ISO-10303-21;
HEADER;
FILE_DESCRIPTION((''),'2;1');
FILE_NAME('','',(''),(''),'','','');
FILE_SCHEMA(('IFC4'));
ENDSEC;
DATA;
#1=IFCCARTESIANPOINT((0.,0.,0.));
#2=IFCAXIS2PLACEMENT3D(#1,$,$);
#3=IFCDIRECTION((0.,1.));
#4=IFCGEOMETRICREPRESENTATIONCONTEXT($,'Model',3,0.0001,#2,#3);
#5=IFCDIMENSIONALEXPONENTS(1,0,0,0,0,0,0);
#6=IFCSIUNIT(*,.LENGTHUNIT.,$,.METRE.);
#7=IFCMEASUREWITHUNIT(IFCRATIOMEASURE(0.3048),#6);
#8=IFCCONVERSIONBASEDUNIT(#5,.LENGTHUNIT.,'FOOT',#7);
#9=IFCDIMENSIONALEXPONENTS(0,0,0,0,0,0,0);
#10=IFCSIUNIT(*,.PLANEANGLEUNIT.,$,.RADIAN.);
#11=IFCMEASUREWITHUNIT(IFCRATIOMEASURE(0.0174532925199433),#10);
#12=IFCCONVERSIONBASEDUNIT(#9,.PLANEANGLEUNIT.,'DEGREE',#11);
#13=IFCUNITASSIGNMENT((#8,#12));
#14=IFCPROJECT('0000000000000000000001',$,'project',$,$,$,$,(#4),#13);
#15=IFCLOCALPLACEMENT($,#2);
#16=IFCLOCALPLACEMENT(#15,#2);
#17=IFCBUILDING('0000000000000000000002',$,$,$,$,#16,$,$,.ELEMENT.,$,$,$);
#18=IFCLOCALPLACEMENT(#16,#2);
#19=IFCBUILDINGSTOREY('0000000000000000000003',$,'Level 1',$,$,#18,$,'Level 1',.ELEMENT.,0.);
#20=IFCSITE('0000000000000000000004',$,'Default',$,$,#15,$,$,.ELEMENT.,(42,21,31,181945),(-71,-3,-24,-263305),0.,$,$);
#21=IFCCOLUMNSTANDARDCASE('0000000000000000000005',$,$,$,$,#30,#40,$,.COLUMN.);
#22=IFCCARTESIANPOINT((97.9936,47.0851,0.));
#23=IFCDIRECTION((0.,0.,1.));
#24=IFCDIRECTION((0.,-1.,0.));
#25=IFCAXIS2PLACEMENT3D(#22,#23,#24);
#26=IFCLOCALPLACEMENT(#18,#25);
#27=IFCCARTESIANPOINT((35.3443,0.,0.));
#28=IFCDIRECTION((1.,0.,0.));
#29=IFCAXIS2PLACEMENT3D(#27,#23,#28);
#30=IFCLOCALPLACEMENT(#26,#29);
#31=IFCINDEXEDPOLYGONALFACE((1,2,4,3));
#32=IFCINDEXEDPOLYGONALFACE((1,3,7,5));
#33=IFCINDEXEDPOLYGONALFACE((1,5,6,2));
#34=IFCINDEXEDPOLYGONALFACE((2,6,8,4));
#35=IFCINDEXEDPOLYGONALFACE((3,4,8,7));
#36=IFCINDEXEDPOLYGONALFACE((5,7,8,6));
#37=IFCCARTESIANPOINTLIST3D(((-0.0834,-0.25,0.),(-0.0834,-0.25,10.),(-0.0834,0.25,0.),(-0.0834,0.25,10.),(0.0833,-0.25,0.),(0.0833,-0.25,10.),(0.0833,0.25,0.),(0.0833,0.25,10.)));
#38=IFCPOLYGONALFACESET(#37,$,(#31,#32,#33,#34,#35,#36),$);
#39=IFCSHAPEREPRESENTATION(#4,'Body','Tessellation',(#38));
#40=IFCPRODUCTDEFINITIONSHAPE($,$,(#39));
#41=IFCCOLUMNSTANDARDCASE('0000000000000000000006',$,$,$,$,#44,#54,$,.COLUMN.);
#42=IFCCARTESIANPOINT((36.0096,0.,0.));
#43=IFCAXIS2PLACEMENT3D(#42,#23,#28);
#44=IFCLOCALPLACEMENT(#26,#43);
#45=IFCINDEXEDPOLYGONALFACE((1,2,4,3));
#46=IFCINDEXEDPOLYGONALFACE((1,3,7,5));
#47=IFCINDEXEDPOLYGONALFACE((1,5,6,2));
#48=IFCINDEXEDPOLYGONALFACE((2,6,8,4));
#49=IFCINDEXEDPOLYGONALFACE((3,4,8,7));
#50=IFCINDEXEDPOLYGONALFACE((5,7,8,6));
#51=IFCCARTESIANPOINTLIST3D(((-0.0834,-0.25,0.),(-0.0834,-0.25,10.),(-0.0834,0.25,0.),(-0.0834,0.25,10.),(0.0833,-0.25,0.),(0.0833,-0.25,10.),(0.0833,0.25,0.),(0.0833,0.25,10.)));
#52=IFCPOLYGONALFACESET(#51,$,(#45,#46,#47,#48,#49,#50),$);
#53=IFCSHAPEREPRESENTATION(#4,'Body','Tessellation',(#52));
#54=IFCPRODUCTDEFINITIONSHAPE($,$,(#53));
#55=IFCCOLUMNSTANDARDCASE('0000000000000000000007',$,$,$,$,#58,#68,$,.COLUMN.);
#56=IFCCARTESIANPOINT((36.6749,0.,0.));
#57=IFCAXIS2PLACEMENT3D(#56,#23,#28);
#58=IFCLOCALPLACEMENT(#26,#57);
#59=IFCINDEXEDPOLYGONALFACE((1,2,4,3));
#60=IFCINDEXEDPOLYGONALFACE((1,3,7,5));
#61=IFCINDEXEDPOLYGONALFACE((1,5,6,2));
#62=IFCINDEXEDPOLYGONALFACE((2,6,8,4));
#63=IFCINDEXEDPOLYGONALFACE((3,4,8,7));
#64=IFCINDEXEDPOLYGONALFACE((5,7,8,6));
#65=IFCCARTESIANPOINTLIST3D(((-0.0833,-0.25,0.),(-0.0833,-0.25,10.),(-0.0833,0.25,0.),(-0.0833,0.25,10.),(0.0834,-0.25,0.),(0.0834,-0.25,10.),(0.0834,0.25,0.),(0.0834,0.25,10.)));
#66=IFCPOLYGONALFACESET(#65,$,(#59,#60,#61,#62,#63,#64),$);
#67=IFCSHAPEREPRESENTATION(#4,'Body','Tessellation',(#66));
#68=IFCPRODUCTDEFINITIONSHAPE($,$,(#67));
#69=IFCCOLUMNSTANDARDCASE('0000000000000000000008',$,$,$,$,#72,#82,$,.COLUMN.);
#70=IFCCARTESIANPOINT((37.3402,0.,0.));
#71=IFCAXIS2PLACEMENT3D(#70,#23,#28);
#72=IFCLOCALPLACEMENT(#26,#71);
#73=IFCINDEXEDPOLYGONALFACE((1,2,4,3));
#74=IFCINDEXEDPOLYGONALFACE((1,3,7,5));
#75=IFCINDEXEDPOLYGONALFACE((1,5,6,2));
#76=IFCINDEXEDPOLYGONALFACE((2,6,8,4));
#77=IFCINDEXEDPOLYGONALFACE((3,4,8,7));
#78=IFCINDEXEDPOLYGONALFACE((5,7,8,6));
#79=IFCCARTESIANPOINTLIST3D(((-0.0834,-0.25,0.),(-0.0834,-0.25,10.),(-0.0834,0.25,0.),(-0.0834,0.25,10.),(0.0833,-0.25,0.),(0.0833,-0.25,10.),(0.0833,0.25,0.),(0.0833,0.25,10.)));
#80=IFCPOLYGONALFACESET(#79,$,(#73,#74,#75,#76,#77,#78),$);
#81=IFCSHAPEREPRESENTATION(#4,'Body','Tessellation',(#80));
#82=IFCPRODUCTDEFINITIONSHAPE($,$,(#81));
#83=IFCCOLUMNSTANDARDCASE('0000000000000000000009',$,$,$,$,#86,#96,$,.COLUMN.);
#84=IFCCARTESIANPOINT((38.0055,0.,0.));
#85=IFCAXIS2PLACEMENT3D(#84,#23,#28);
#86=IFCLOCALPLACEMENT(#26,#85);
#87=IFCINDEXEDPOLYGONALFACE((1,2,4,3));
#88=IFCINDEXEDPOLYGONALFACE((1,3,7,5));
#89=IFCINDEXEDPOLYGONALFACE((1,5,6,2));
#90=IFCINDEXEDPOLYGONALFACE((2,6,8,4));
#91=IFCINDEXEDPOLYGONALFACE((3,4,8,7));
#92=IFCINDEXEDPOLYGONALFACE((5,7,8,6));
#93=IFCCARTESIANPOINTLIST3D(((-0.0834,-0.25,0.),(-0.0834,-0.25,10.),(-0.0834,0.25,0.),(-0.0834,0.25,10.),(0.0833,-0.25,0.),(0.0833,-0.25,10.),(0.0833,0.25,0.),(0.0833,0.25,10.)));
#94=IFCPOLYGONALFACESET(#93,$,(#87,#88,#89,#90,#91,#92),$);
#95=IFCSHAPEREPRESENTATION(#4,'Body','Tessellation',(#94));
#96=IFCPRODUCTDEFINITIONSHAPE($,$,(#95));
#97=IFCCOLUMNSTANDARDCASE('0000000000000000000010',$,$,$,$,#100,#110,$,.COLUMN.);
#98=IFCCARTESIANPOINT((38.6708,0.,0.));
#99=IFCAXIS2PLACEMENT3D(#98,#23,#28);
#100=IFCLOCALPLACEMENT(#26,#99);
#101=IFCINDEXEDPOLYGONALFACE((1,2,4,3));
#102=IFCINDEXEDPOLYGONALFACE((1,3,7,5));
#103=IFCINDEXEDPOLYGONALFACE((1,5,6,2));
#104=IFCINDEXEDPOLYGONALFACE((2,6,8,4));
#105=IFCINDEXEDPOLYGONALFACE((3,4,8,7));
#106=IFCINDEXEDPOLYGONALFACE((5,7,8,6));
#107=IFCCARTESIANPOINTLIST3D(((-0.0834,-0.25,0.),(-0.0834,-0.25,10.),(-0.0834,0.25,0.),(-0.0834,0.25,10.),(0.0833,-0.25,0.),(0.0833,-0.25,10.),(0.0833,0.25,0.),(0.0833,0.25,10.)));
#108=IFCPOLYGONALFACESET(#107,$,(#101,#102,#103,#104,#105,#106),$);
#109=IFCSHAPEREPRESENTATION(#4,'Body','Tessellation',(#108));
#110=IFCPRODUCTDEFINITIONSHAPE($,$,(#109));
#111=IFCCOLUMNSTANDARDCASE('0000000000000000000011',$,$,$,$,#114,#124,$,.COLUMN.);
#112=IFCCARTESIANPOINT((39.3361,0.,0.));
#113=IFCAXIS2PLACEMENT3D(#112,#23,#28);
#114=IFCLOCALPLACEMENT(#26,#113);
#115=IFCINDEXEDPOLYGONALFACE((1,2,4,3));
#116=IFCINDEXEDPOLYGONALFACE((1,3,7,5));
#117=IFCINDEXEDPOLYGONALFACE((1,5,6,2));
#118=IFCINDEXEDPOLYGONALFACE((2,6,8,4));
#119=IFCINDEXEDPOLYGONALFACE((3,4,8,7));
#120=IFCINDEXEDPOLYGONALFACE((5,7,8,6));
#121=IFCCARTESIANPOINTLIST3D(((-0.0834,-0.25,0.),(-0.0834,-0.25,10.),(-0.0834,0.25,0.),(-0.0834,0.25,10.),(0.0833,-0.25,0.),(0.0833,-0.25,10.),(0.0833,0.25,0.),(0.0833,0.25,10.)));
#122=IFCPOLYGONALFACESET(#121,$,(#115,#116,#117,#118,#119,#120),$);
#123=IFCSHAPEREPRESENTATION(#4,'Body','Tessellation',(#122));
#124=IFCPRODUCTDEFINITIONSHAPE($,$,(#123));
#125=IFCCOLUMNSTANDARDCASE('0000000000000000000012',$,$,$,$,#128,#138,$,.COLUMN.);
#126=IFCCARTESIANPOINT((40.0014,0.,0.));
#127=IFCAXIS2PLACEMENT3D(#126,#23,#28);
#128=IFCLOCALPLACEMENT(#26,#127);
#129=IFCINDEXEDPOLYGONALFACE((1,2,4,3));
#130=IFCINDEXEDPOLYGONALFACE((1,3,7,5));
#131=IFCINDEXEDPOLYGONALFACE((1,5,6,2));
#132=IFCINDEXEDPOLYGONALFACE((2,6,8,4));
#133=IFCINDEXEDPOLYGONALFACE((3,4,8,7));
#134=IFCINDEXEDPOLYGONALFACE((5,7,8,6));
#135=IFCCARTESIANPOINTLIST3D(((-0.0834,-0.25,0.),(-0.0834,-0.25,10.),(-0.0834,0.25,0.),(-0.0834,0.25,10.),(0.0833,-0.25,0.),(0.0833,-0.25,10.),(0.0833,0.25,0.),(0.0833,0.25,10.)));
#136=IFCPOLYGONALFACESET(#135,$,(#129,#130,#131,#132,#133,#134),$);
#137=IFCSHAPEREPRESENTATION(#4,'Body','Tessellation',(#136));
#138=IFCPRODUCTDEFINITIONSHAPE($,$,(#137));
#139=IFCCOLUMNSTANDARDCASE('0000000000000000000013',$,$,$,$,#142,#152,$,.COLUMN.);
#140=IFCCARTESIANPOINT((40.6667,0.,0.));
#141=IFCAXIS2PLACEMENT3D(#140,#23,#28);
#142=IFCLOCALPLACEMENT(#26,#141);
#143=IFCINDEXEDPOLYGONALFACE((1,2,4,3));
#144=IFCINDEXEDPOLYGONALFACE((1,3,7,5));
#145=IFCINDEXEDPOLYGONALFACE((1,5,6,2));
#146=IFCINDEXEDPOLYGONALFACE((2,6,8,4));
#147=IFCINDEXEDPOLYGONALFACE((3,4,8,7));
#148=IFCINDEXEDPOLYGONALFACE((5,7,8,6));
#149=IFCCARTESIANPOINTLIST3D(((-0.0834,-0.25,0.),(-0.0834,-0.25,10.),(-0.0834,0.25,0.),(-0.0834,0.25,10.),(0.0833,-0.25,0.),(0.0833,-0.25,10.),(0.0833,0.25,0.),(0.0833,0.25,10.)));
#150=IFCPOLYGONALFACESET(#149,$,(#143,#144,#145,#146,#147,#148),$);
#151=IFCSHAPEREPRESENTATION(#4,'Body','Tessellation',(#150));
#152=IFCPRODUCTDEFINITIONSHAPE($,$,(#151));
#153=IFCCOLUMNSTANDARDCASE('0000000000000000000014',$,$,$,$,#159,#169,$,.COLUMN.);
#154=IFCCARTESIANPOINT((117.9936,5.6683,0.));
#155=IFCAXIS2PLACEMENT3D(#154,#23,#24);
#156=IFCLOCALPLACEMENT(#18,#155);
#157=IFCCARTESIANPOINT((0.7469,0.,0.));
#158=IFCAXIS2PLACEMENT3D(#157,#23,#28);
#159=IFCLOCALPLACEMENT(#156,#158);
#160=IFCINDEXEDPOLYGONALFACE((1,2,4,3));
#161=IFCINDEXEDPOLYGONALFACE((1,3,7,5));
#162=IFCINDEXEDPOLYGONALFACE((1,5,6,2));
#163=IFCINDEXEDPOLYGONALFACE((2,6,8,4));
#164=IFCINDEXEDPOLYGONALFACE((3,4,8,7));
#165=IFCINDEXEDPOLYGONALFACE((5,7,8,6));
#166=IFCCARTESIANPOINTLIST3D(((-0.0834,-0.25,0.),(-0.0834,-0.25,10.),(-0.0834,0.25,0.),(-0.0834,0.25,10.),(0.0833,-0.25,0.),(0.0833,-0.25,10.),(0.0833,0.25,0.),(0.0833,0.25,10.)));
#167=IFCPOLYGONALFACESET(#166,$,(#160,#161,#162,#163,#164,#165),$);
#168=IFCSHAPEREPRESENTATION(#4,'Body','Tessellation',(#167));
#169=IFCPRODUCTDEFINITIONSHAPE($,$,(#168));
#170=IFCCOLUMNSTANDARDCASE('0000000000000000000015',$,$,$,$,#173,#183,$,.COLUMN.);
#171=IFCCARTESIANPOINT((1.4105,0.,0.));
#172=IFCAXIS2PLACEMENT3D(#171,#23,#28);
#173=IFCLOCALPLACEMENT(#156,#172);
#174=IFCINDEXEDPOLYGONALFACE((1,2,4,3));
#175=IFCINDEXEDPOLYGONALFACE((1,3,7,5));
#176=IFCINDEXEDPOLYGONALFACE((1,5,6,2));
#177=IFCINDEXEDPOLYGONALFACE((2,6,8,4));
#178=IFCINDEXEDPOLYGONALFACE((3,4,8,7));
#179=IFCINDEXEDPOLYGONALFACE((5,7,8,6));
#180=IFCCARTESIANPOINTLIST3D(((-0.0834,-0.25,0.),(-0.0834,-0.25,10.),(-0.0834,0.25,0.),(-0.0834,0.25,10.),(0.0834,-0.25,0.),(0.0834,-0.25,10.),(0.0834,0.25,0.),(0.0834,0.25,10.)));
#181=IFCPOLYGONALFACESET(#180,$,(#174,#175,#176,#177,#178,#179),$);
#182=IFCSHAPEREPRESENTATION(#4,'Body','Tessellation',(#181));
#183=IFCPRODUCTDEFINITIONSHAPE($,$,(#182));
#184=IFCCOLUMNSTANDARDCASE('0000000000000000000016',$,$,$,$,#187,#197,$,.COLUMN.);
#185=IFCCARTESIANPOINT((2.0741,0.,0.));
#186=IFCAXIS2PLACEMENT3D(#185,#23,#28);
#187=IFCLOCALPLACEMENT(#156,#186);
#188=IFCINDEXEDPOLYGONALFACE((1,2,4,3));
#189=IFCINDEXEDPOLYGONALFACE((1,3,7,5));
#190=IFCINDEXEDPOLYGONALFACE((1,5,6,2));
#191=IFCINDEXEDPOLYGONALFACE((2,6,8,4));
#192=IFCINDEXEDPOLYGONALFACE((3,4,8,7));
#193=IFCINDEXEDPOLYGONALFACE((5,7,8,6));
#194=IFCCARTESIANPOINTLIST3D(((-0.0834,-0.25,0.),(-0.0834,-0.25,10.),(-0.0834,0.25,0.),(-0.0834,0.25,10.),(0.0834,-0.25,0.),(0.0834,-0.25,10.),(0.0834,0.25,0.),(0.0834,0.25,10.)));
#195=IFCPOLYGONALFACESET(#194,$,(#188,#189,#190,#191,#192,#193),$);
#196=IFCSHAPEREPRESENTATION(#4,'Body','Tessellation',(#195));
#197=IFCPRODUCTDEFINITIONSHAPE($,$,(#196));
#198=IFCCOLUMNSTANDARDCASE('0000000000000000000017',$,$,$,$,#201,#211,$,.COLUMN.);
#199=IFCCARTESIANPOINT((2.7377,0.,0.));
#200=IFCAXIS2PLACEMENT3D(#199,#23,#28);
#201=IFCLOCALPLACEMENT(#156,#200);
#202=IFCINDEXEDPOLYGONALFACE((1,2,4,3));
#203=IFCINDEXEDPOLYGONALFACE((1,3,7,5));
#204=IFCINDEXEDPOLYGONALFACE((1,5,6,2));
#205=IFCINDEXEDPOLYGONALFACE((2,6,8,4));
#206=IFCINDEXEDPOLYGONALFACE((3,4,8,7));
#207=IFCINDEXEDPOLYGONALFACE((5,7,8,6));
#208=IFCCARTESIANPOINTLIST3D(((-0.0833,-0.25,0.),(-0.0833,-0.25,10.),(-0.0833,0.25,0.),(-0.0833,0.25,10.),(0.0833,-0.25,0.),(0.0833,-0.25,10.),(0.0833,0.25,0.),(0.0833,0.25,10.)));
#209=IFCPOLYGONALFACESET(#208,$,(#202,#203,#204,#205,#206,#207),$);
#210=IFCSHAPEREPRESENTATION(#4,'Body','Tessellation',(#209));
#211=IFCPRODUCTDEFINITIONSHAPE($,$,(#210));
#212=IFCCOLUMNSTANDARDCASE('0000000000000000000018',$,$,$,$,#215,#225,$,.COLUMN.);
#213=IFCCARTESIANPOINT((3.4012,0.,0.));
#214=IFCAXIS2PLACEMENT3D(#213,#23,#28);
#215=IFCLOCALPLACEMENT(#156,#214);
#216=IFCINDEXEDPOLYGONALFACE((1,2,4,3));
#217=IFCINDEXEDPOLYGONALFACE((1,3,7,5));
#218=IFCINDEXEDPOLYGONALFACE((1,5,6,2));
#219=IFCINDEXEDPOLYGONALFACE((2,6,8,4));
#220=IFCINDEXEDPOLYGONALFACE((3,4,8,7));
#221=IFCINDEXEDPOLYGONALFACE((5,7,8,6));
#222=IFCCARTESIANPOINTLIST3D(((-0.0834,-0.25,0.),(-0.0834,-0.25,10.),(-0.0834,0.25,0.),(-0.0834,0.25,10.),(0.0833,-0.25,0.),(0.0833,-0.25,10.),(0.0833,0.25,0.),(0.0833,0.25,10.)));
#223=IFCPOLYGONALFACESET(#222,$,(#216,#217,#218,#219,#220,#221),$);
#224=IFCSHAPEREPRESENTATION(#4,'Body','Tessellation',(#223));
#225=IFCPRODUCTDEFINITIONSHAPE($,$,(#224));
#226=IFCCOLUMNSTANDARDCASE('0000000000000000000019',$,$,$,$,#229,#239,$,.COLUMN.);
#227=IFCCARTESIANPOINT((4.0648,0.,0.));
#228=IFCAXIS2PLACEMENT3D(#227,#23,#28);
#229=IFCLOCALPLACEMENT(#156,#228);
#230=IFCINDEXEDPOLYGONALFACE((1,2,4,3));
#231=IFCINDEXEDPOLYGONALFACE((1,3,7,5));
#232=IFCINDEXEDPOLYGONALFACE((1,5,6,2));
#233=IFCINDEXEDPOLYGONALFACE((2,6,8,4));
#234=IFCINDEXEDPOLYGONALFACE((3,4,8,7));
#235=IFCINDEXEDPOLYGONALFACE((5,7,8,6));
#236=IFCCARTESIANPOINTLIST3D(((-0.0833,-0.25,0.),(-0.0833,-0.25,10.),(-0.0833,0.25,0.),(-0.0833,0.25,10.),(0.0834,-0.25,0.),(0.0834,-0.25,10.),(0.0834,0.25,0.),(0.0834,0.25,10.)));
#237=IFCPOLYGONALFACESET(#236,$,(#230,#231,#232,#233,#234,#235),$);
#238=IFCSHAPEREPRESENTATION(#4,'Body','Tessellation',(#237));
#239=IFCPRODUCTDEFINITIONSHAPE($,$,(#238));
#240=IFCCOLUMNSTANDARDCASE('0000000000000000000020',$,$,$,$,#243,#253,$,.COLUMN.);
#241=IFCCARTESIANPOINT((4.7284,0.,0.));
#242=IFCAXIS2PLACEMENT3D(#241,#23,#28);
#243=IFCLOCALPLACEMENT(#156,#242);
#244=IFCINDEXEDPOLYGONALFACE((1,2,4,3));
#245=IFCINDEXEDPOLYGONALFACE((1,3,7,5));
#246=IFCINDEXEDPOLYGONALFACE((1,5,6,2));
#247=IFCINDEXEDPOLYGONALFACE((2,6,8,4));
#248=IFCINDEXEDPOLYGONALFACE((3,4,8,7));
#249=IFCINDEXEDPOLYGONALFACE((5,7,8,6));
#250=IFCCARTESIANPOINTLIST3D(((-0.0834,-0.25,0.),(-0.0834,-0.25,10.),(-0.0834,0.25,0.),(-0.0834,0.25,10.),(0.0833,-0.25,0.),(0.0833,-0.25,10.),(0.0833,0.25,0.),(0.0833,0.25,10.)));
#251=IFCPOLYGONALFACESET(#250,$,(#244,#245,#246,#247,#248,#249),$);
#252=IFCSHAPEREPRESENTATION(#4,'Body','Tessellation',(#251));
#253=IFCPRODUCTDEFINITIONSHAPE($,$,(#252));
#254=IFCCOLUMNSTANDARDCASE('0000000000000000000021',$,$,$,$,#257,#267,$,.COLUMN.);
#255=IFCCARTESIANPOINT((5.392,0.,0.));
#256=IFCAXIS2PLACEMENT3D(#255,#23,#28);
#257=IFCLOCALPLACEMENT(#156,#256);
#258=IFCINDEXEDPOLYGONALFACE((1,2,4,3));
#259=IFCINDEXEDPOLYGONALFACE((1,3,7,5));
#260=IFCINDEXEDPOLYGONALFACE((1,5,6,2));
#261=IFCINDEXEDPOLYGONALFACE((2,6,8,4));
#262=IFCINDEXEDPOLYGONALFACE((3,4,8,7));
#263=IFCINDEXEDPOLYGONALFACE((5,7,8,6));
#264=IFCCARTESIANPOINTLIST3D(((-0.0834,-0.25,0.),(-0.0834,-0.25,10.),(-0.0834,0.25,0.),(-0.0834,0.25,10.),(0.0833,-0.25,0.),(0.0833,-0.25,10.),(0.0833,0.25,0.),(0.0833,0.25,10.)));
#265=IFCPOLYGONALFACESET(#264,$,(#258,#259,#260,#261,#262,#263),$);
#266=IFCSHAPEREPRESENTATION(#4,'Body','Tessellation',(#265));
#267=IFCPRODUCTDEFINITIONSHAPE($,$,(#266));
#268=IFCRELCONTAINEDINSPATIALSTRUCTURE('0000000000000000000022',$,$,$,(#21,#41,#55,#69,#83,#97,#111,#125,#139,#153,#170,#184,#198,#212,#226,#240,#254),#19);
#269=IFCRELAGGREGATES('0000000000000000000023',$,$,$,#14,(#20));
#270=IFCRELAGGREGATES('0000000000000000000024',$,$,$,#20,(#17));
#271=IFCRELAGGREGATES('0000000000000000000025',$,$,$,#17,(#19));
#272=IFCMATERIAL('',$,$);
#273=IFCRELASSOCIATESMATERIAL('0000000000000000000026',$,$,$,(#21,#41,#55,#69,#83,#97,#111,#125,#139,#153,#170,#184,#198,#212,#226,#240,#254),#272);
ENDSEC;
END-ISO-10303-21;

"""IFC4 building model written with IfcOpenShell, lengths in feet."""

from ifc_helpers import new_model, entity, si_unit, converted_unit, direction, frame, origin, place, context, project, spatial, rectangle, extrude, material, element, save


model = new_model("IFC4")

# Units and contexts
model_context = context("Model", 3, precision=0.0001, world=origin(), true_north=direction((0.0, 1.0)))
ifc_project = project(units=[converted_unit("LENGTHUNIT", "FOOT", entity("IfcRatioMeasure", 0.3048), si_unit("LENGTHUNIT", "METRE"), dimensions=[1, 0, 0, 0, 0, 0, 0]), converted_unit("PLANEANGLEUNIT", "DEGREE", entity("IfcRatioMeasure", 0.0174532925199433), si_unit("PLANEANGLEUNIT", "RADIAN"), dimensions=[0, 0, 0, 0, 0, 0, 0])], contexts=[model_context])

# Site, building, storey
site_placement = place(None, origin())
site = spatial("IfcSite", under=ifc_project, at=site_placement, Name="Default", CompositionType="ELEMENT", RefLatitude=(42, 21, 31, 181945), RefLongitude=(-71, -3, -24, -263305), RefElevation=0.0)
building_placement = place(site_placement, origin())
building = spatial("IfcBuilding", under=site, at=building_placement, CompositionType="ELEMENT")
storey_placement = place(building_placement, origin())
storey = spatial("IfcBuildingStorey", under=building, at=storey_placement, Name="Level 1", LongName="Level 1", CompositionType="ELEMENT", Elevation=0.0)

# Columns
ifc_material_1 = material(Name="")
placement = place(storey_placement, frame((97.9936, 47.0851, 0.0), z_axis=(0.0, 0.0, 1.0), x_axis=(0.0, -1.0, 0.0)))
for number, where, z_axis, x_axis in (
    (1, (35.3443, 0.0, 0.0), (0.0, 0.0, 1.0), (1.0, 0.0, 0.0)),
    (2, (36.0096, 0.0, 0.0), (0.0, 0.0, 1.0), (1.0, 0.0, 0.0)),
    (3, (36.6749, 0.0, 0.0), (0.0, 0.0, 1.0), (1.0, 0.0, 0.0)),
    (4, (37.3402, 0.0, 0.0), (0.0, 0.0, 1.0), (1.0, 0.0, 0.0)),
    (5, (38.0055, 0.0, 0.0), (0.0, 0.0, 1.0), (1.0, 0.0, 0.0)),
    (6, (38.6708, 0.0, 0.0), (0.0, 0.0, 1.0), (1.0, 0.0, 0.0)),
    (7, (39.3361, 0.0, 0.0), (0.0, 0.0, 1.0), (1.0, 0.0, 0.0)),
    (8, (40.0014, 0.0, 0.0), (0.0, 0.0, 1.0), (1.0, 0.0, 0.0)),
    (9, (40.6667, 0.0, 0.0), (0.0, 0.0, 1.0), (1.0, 0.0, 0.0)),
):
    element("IfcColumnStandardCase", number, at=place(placement, frame(where, z_axis=z_axis, x_axis=x_axis)), inside=storey, material=ifc_material_1, PredefinedType="COLUMN", context=model_context, shape_type="SweptSolid", body=[
        extrude(rectangle(XDim=0.1667, YDim=0.5), origin(), (0.0, 0.0, 1.0), 10.0),
    ])
wall_placement = place(storey_placement, frame((117.9936, 5.6683, 0.0), z_axis=(0.0, 0.0, 1.0), x_axis=(0.0, -1.0, 0.0)))
for number, where, z_axis, x_axis in (
    (10, (0.7469, 0.0, 0.0), (0.0, 0.0, 1.0), (1.0, 0.0, 0.0)),
    (11, (1.4105, 0.0, 0.0), (0.0, 0.0, 1.0), (1.0, 0.0, 0.0)),
    (12, (2.0741, 0.0, 0.0), (0.0, 0.0, 1.0), (1.0, 0.0, 0.0)),
    (13, (2.7377, 0.0, 0.0), (0.0, 0.0, 1.0), (1.0, 0.0, 0.0)),
    (14, (3.4012, 0.0, 0.0), (0.0, 0.0, 1.0), (1.0, 0.0, 0.0)),
    (15, (4.0648, 0.0, 0.0), (0.0, 0.0, 1.0), (1.0, 0.0, 0.0)),
    (16, (4.7284, 0.0, 0.0), (0.0, 0.0, 1.0), (1.0, 0.0, 0.0)),
    (17, (5.392, 0.0, 0.0), (0.0, 0.0, 1.0), (1.0, 0.0, 0.0)),
):
    element("IfcColumnStandardCase", number, at=place(wall_placement, frame(where, z_axis=z_axis, x_axis=x_axis)), inside=storey, material=ifc_material_1, PredefinedType="COLUMN", context=model_context, shape_type="SweptSolid", body=[
        extrude(rectangle(XDim=0.1667, YDim=0.5), origin(), (0.0, 0.0, 1.0), 10.0),
    ])

save(model, "model.ifc")
